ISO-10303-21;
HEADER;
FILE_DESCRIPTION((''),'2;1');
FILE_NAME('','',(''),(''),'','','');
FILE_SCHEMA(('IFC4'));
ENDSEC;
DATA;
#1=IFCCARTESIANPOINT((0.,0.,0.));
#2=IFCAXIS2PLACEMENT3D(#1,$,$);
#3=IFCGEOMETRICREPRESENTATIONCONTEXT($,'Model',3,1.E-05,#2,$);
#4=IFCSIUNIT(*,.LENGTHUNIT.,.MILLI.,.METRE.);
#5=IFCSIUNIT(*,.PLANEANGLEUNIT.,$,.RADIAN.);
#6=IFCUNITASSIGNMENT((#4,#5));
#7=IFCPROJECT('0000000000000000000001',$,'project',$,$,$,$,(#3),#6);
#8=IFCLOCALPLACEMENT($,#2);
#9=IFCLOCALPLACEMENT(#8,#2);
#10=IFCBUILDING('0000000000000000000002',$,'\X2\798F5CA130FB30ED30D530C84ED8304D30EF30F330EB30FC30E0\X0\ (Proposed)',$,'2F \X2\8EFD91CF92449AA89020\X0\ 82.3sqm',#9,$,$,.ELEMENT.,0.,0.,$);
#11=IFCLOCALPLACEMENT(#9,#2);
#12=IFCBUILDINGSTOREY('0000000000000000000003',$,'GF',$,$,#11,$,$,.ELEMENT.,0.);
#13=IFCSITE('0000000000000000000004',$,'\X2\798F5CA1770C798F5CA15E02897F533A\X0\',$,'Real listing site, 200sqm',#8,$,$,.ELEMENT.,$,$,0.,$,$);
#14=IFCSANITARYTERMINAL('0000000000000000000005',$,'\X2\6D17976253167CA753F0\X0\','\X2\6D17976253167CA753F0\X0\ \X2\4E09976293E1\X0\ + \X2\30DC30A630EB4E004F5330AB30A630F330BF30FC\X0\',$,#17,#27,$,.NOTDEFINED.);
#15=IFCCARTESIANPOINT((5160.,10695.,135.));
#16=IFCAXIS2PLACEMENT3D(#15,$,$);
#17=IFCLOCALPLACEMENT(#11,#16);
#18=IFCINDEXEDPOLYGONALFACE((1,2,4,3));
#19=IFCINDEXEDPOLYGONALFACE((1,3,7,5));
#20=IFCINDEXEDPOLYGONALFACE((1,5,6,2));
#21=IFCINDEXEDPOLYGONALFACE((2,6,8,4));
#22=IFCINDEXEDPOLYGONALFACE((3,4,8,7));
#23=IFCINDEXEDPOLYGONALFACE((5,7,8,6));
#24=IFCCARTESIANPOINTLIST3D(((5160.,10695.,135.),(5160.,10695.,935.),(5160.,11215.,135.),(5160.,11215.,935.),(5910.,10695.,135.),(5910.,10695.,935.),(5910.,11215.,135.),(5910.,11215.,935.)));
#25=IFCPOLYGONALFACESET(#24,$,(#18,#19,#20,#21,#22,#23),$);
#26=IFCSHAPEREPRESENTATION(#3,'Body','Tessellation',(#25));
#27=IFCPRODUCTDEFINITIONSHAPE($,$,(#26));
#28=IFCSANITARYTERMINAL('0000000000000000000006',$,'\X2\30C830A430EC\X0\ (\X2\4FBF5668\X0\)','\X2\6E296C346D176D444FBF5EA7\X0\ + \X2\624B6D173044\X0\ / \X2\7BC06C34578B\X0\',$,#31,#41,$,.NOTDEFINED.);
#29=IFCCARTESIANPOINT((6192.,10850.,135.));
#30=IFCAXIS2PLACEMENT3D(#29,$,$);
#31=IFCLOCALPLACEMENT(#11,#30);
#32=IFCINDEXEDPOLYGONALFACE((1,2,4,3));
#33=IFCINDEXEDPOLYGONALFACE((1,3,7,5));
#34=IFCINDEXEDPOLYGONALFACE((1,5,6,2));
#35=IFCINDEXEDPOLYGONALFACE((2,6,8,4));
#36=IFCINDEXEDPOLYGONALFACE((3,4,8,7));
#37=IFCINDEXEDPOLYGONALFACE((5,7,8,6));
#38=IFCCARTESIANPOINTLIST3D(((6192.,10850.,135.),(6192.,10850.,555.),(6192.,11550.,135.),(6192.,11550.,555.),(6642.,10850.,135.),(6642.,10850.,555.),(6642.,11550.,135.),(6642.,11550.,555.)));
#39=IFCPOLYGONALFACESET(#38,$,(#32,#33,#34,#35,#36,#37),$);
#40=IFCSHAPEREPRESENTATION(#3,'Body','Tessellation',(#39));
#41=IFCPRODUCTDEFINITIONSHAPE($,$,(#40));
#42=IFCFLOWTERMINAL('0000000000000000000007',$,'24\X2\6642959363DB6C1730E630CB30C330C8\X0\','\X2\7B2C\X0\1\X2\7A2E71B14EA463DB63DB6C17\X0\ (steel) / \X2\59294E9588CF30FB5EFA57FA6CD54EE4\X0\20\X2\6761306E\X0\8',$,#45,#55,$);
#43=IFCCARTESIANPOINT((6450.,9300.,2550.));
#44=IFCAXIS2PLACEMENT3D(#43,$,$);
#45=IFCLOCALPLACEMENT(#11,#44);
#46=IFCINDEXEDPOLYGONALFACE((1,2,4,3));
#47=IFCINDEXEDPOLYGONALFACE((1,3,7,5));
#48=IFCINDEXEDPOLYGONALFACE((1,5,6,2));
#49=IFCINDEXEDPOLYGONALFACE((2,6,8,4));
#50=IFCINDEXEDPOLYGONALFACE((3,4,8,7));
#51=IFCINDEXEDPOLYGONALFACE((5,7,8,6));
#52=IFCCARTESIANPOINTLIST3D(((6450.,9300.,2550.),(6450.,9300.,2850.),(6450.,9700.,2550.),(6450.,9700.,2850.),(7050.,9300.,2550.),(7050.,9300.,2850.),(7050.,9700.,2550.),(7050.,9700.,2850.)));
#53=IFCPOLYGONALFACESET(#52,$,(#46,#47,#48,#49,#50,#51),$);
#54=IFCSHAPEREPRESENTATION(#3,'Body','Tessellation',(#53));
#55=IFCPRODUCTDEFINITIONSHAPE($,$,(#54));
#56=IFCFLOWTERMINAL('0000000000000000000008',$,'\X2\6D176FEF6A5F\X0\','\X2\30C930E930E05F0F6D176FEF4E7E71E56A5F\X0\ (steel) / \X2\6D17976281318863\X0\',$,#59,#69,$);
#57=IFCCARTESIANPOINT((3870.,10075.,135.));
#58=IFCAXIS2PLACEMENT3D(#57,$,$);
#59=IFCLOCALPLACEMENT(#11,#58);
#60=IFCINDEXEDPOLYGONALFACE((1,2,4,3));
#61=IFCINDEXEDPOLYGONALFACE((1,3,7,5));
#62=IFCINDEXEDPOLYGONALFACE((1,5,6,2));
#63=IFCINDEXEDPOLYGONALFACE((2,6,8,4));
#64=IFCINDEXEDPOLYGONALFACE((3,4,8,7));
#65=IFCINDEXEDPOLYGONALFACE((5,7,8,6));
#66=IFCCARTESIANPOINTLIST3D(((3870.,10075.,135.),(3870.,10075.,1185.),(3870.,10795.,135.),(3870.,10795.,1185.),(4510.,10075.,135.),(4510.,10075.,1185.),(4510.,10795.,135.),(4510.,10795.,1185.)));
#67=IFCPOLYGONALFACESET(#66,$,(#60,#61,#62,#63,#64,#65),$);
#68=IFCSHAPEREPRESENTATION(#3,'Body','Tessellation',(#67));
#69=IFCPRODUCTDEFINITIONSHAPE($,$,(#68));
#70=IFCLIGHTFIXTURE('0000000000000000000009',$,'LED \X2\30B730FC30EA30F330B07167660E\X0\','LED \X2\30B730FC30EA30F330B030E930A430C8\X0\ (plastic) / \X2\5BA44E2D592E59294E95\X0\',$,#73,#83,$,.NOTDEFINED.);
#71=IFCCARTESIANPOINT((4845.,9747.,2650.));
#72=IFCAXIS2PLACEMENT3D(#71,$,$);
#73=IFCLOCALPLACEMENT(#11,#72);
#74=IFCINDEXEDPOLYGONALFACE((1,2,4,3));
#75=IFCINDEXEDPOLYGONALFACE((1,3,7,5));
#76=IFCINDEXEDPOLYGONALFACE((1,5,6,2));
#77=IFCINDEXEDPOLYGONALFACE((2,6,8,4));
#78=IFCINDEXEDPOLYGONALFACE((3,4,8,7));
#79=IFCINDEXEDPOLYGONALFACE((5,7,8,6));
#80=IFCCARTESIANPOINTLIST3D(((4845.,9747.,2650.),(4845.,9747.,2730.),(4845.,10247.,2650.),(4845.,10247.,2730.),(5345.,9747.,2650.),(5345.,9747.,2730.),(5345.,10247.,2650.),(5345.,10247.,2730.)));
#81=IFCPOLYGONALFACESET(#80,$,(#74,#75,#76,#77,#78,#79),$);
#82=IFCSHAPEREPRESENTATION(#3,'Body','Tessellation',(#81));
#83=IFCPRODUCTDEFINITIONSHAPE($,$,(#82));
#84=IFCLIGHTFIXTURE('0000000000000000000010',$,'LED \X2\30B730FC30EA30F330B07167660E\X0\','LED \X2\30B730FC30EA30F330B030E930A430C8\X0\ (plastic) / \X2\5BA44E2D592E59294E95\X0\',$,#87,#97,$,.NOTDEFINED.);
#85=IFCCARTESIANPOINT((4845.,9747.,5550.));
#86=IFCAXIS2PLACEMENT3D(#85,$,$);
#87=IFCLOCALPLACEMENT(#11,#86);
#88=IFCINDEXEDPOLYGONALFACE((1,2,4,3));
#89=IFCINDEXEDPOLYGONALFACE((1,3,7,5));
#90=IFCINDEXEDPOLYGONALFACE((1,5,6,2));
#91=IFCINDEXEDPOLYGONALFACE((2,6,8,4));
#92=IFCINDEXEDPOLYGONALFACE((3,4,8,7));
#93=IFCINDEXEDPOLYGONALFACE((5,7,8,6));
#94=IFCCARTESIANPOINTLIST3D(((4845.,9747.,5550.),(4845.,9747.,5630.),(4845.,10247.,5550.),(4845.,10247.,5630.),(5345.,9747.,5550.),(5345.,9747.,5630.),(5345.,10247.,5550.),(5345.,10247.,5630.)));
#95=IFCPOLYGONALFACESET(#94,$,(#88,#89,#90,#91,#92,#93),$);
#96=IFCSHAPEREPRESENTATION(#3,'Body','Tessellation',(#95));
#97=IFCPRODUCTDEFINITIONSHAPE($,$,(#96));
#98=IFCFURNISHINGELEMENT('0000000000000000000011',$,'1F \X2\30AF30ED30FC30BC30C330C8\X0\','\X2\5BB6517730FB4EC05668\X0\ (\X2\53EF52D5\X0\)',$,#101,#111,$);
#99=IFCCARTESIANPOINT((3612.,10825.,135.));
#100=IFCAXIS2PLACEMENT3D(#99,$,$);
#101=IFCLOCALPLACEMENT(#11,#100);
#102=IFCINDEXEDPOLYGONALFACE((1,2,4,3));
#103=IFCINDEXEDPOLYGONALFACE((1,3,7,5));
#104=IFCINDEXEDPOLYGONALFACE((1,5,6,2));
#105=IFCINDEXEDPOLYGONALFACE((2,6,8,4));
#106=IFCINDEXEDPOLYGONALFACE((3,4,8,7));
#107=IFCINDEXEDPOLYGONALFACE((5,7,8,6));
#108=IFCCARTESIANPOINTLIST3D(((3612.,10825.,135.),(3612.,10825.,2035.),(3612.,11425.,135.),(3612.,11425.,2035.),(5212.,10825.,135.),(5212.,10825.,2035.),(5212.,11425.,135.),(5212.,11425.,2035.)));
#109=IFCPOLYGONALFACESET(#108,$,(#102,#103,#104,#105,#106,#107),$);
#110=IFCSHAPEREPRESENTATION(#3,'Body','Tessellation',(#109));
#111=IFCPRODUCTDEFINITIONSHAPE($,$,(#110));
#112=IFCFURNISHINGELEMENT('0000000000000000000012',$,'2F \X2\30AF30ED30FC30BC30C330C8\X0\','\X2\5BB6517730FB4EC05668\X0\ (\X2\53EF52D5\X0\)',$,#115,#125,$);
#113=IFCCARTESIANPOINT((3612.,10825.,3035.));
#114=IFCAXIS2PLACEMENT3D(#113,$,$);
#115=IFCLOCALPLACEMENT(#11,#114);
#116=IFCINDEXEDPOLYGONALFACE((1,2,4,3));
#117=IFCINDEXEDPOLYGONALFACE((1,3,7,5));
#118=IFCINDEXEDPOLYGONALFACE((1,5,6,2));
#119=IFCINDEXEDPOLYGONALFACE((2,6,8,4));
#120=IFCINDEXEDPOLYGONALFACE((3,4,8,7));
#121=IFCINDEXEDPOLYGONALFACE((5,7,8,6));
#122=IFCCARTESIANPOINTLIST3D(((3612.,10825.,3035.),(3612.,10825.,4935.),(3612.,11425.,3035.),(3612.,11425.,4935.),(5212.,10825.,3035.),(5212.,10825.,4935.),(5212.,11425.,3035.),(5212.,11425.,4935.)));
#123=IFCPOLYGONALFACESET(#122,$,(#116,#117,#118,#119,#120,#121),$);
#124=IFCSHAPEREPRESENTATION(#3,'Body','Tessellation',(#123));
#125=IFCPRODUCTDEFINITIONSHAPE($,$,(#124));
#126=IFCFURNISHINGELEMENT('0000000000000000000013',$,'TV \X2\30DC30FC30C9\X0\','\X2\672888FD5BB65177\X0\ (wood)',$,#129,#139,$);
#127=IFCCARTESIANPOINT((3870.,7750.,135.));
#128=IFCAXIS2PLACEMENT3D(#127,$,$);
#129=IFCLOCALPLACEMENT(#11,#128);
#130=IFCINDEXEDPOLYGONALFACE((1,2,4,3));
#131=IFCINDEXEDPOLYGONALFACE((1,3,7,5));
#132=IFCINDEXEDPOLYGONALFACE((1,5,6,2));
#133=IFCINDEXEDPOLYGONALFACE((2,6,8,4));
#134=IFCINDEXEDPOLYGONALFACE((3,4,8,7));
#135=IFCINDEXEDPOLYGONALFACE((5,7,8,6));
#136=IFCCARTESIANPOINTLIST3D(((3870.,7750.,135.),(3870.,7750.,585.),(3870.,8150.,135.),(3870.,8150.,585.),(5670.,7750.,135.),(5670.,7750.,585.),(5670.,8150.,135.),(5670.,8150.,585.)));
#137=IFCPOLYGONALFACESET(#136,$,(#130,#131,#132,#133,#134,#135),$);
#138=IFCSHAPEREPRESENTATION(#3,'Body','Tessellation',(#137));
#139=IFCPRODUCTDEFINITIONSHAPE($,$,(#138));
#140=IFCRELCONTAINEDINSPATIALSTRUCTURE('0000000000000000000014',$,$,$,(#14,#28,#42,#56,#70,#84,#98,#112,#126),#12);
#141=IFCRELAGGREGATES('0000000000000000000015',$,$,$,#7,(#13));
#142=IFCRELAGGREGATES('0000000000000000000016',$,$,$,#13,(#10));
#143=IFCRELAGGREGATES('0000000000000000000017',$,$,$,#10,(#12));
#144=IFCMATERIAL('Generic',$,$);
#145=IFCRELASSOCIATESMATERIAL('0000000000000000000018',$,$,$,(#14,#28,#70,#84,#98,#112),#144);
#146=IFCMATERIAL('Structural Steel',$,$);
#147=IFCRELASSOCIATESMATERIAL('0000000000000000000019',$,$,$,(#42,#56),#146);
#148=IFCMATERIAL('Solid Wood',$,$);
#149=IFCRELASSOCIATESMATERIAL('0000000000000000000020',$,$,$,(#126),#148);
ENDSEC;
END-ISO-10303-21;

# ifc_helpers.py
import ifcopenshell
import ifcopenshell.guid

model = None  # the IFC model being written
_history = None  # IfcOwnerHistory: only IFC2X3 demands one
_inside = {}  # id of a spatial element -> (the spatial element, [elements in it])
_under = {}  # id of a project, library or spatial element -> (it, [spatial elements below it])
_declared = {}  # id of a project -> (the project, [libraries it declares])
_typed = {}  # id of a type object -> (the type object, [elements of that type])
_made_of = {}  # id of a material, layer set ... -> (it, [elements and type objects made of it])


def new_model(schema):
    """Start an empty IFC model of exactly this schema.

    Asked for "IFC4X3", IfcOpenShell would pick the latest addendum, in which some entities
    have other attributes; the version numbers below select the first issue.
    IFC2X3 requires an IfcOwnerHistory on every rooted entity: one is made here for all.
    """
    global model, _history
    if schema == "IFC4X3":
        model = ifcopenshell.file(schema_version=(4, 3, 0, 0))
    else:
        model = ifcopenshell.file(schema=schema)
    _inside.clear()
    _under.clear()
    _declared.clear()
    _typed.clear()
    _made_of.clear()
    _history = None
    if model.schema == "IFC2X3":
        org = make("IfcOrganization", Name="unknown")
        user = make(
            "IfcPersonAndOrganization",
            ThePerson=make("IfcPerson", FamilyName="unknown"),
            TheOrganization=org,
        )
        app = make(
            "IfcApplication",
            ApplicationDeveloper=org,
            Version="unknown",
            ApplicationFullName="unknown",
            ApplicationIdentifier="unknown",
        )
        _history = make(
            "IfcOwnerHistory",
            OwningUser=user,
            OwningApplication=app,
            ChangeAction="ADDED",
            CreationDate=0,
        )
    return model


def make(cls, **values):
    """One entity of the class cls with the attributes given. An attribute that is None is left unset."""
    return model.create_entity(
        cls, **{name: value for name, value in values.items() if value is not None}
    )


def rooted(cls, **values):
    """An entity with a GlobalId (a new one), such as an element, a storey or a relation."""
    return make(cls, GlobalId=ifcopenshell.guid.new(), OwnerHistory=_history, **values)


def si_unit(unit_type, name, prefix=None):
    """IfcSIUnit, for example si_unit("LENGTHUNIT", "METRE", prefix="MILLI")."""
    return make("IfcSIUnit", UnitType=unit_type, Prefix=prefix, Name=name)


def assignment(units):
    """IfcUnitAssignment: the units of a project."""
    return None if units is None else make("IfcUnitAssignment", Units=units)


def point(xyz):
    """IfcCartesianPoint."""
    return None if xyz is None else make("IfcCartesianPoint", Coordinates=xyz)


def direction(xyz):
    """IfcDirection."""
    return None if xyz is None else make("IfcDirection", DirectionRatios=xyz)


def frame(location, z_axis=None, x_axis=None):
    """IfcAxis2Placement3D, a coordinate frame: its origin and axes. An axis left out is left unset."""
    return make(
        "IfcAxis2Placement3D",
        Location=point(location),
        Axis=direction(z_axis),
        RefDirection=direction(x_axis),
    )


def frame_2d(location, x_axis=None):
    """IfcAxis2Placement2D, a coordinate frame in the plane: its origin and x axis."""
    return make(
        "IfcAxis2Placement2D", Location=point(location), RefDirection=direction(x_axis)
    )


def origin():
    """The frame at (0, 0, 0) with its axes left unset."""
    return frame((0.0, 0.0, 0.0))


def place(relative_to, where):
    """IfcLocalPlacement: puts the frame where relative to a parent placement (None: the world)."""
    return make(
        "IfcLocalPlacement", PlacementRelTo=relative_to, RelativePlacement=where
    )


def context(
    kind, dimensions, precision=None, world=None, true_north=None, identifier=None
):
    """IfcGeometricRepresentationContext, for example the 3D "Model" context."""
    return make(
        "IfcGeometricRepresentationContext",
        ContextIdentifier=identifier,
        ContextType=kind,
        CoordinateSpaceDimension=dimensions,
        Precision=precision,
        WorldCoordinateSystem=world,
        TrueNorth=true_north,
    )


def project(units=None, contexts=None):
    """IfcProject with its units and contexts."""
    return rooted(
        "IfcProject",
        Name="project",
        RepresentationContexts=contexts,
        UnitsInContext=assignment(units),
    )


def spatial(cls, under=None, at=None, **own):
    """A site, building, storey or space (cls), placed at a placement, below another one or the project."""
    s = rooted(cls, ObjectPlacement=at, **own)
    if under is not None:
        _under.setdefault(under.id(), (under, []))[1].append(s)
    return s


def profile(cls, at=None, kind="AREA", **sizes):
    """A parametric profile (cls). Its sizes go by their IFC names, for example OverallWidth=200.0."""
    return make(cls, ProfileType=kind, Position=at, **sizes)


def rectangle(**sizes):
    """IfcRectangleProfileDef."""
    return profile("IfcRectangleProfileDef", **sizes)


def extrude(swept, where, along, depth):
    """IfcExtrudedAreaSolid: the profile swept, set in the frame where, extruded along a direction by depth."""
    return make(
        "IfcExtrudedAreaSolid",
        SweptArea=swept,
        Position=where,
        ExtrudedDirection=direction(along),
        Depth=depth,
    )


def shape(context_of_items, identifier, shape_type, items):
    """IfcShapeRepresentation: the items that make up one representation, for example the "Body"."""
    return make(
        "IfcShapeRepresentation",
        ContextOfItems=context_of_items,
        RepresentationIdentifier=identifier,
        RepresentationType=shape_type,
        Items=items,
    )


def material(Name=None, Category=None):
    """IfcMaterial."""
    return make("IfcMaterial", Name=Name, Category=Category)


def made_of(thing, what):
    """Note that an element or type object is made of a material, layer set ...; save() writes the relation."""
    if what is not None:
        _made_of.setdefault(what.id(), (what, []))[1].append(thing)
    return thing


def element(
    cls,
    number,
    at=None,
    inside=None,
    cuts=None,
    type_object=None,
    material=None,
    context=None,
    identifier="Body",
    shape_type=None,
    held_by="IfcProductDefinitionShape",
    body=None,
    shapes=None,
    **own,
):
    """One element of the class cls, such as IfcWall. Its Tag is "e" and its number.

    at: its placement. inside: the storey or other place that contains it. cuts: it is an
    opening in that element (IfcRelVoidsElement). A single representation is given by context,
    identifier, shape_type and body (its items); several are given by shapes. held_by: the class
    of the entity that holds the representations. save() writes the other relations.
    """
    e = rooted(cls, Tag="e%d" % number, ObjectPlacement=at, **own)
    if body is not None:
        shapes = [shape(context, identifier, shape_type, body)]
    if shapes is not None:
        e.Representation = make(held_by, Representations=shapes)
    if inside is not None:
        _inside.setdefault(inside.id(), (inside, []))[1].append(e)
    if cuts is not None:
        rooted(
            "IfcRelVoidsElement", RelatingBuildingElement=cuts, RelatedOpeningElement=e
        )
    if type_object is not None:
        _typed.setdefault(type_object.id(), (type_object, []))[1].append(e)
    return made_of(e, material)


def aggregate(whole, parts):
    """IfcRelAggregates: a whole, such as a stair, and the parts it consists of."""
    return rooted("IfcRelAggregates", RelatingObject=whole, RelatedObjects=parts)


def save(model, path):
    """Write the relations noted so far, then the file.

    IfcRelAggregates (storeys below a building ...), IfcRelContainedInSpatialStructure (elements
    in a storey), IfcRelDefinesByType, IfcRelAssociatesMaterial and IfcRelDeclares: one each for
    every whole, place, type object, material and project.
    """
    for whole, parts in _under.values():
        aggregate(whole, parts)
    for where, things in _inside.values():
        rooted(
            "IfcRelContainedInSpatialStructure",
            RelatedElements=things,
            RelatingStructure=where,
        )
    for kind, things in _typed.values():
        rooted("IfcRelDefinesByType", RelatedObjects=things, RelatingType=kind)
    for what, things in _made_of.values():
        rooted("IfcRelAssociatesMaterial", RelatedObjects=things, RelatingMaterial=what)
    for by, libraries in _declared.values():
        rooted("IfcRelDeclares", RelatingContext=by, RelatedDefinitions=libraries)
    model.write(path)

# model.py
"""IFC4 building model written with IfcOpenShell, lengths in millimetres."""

from ifc_helpers import new_model, si_unit, frame, frame_2d, origin, place, context, project, spatial, rectangle, extrude, material, element, save


model = new_model("IFC4")

# Units and contexts
model_context = context("Model", 3, precision=1e-05, world=origin())
ifc_project = project(units=[si_unit("LENGTHUNIT", "METRE", prefix="MILLI"), si_unit("PLANEANGLEUNIT", "RADIAN")], contexts=[model_context])

# Site, building, storey
site_placement = place(None, origin())
site = spatial("IfcSite", under=ifc_project, at=site_placement, Name="福岡県福岡市西区", ObjectType="Real listing site, 200sqm", CompositionType="ELEMENT", RefElevation=0.0)
building_placement = place(site_placement, origin())
building = spatial("IfcBuilding", under=site, at=building_placement, Name="福岡・ロフト付きワンルーム (Proposed)", ObjectType="2F 軽量鉄骨造 82.3sqm", CompositionType="ELEMENT", ElevationOfRefHeight=0.0, ElevationOfTerrain=0.0)
storey_placement = place(building_placement, origin())
storey = spatial("IfcBuildingStorey", under=building, at=storey_placement, Name="GF", CompositionType="ELEMENT", Elevation=0.0)

# Shared definitions
ifc_material_1 = material(Name="Solid Wood")

# Sanitary terminals
ifc_material_2 = material(Name="Generic")
sanitary_terminal_1_placement = place(storey_placement, frame((5160.0, 10695.0, 135.0)))
element("IfcSanitaryTerminal", 1, at=sanitary_terminal_1_placement, inside=storey, material=ifc_material_2, Name="洗面化粧台", Description="洗面化粧台 三面鏡 + ボウル一体カウンター", PredefinedType="NOTDEFINED", context=model_context, shape_type="SweptSolid", body=[
    extrude(rectangle(XDim=750.0, YDim=520.0, at=frame_2d((375.0, 260.0))), frame((5160.0, 10695.0, 135.0)), (0.0, 0.0, 1.0), 800.0),
])
sanitary_terminal_2_placement = place(storey_placement, frame((6192.0, 10850.0, 135.0)))
element("IfcSanitaryTerminal", 2, at=sanitary_terminal_2_placement, inside=storey, material=ifc_material_2, Name="トイレ (便器)", Description="温水洗浄便座 + 手洗い / 節水型", PredefinedType="NOTDEFINED", context=model_context, shape_type="SweptSolid", body=[
    extrude(rectangle(XDim=450.0, YDim=700.0, at=frame_2d((225.0, 350.0))), frame((6192.0, 10850.0, 135.0)), (0.0, 0.0, 1.0), 420.0),
])

# Flow terminals
ifc_material_3 = material(Name="Structural Steel")
flow_terminal_1_placement = place(storey_placement, frame((6450.0, 9300.0, 2550.0)))
element("IfcFlowTerminal", 3, at=flow_terminal_1_placement, inside=storey, material=ifc_material_3, Name="24時間換気ユニット", Description="第1種熱交換換気 (steel) / 天井裏・建基法令20条の8", context=model_context, shape_type="SweptSolid", body=[
    extrude(rectangle(XDim=600.0, YDim=400.0, at=frame_2d((300.0, 200.0))), frame((6450.0, 9300.0, 2550.0)), (0.0, 0.0, 1.0), 300.0),
])
flow_terminal_2_placement = place(storey_placement, frame((3870.0, 10075.0, 135.0)))
element("IfcFlowTerminal", 4, at=flow_terminal_2_placement, inside=storey, material=ifc_material_3, Name="洗濯機", Description="ドラム式洗濯乾燥機 (steel) / 洗面脱衣", context=model_context, shape_type="SweptSolid", body=[
    extrude(rectangle(XDim=640.0, YDim=720.0, at=frame_2d((320.0, 360.0))), frame((3870.0, 10075.0, 135.0)), (0.0, 0.0, 1.0), 1050.0),
])

# Light fixtures
light_fixture_1_placement = place(storey_placement, frame((4845.0, 9747.0, 2650.0)))
element("IfcLightFixture", 5, at=light_fixture_1_placement, inside=storey, material=ifc_material_2, Name="LED シーリング照明", Description="LED シーリングライト (plastic) / 室中央天井", PredefinedType="NOTDEFINED", context=model_context, shape_type="SweptSolid", body=[
    extrude(rectangle(XDim=500.0, YDim=500.0, at=frame_2d((250.0, 250.0))), frame((4845.0, 9747.0, 2650.0)), (0.0, 0.0, 1.0), 80.0),
])
light_fixture_2_placement = place(storey_placement, frame((4845.0, 9747.0, 5550.0)))
element("IfcLightFixture", 6, at=light_fixture_2_placement, inside=storey, material=ifc_material_2, Name="LED シーリング照明", Description="LED シーリングライト (plastic) / 室中央天井", PredefinedType="NOTDEFINED", context=model_context, shape_type="SweptSolid", body=[
    extrude(rectangle(XDim=500.0, YDim=500.0, at=frame_2d((250.0, 250.0))), frame((4845.0, 9747.0, 5550.0)), (0.0, 0.0, 1.0), 80.0),
])

# Furnishing elements
furnishing_1_placement = place(storey_placement, frame((3612.0, 10825.0, 135.0)))
element("IfcFurnishingElement", 7, at=furnishing_1_placement, inside=storey, material=ifc_material_2, Name="1F クローゼット", Description="家具・什器 (可動)", context=model_context, shape_type="SweptSolid", body=[
    extrude(rectangle(XDim=1600.0, YDim=600.0, at=frame_2d((800.0, 300.0))), frame((3612.0, 10825.0, 135.0)), (0.0, 0.0, 1.0), 1900.0),
])
furnishing_2_placement = place(storey_placement, frame((3612.0, 10825.0, 3035.0)))
element("IfcFurnishingElement", 8, at=furnishing_2_placement, inside=storey, material=ifc_material_2, Name="2F クローゼット", Description="家具・什器 (可動)", context=model_context, shape_type="SweptSolid", body=[
    extrude(rectangle(XDim=1600.0, YDim=600.0, at=frame_2d((800.0, 300.0))), frame((3612.0, 10825.0, 3035.0)), (0.0, 0.0, 1.0), 1900.0),
])
furnishing_3_placement = place(storey_placement, frame((3870.0, 7750.0, 135.0)))
element("IfcFurnishingElement", 9, at=furnishing_3_placement, inside=storey, material=ifc_material_1, Name="TV ボード", Description="木製家具 (wood)", context=model_context, shape_type="SweptSolid", body=[
    extrude(rectangle(XDim=1800.0, YDim=400.0, at=frame_2d((900.0, 200.0))), frame((3870.0, 7750.0, 135.0)), (0.0, 0.0, 1.0), 450.0),
])

save(model, "model.ifc")
